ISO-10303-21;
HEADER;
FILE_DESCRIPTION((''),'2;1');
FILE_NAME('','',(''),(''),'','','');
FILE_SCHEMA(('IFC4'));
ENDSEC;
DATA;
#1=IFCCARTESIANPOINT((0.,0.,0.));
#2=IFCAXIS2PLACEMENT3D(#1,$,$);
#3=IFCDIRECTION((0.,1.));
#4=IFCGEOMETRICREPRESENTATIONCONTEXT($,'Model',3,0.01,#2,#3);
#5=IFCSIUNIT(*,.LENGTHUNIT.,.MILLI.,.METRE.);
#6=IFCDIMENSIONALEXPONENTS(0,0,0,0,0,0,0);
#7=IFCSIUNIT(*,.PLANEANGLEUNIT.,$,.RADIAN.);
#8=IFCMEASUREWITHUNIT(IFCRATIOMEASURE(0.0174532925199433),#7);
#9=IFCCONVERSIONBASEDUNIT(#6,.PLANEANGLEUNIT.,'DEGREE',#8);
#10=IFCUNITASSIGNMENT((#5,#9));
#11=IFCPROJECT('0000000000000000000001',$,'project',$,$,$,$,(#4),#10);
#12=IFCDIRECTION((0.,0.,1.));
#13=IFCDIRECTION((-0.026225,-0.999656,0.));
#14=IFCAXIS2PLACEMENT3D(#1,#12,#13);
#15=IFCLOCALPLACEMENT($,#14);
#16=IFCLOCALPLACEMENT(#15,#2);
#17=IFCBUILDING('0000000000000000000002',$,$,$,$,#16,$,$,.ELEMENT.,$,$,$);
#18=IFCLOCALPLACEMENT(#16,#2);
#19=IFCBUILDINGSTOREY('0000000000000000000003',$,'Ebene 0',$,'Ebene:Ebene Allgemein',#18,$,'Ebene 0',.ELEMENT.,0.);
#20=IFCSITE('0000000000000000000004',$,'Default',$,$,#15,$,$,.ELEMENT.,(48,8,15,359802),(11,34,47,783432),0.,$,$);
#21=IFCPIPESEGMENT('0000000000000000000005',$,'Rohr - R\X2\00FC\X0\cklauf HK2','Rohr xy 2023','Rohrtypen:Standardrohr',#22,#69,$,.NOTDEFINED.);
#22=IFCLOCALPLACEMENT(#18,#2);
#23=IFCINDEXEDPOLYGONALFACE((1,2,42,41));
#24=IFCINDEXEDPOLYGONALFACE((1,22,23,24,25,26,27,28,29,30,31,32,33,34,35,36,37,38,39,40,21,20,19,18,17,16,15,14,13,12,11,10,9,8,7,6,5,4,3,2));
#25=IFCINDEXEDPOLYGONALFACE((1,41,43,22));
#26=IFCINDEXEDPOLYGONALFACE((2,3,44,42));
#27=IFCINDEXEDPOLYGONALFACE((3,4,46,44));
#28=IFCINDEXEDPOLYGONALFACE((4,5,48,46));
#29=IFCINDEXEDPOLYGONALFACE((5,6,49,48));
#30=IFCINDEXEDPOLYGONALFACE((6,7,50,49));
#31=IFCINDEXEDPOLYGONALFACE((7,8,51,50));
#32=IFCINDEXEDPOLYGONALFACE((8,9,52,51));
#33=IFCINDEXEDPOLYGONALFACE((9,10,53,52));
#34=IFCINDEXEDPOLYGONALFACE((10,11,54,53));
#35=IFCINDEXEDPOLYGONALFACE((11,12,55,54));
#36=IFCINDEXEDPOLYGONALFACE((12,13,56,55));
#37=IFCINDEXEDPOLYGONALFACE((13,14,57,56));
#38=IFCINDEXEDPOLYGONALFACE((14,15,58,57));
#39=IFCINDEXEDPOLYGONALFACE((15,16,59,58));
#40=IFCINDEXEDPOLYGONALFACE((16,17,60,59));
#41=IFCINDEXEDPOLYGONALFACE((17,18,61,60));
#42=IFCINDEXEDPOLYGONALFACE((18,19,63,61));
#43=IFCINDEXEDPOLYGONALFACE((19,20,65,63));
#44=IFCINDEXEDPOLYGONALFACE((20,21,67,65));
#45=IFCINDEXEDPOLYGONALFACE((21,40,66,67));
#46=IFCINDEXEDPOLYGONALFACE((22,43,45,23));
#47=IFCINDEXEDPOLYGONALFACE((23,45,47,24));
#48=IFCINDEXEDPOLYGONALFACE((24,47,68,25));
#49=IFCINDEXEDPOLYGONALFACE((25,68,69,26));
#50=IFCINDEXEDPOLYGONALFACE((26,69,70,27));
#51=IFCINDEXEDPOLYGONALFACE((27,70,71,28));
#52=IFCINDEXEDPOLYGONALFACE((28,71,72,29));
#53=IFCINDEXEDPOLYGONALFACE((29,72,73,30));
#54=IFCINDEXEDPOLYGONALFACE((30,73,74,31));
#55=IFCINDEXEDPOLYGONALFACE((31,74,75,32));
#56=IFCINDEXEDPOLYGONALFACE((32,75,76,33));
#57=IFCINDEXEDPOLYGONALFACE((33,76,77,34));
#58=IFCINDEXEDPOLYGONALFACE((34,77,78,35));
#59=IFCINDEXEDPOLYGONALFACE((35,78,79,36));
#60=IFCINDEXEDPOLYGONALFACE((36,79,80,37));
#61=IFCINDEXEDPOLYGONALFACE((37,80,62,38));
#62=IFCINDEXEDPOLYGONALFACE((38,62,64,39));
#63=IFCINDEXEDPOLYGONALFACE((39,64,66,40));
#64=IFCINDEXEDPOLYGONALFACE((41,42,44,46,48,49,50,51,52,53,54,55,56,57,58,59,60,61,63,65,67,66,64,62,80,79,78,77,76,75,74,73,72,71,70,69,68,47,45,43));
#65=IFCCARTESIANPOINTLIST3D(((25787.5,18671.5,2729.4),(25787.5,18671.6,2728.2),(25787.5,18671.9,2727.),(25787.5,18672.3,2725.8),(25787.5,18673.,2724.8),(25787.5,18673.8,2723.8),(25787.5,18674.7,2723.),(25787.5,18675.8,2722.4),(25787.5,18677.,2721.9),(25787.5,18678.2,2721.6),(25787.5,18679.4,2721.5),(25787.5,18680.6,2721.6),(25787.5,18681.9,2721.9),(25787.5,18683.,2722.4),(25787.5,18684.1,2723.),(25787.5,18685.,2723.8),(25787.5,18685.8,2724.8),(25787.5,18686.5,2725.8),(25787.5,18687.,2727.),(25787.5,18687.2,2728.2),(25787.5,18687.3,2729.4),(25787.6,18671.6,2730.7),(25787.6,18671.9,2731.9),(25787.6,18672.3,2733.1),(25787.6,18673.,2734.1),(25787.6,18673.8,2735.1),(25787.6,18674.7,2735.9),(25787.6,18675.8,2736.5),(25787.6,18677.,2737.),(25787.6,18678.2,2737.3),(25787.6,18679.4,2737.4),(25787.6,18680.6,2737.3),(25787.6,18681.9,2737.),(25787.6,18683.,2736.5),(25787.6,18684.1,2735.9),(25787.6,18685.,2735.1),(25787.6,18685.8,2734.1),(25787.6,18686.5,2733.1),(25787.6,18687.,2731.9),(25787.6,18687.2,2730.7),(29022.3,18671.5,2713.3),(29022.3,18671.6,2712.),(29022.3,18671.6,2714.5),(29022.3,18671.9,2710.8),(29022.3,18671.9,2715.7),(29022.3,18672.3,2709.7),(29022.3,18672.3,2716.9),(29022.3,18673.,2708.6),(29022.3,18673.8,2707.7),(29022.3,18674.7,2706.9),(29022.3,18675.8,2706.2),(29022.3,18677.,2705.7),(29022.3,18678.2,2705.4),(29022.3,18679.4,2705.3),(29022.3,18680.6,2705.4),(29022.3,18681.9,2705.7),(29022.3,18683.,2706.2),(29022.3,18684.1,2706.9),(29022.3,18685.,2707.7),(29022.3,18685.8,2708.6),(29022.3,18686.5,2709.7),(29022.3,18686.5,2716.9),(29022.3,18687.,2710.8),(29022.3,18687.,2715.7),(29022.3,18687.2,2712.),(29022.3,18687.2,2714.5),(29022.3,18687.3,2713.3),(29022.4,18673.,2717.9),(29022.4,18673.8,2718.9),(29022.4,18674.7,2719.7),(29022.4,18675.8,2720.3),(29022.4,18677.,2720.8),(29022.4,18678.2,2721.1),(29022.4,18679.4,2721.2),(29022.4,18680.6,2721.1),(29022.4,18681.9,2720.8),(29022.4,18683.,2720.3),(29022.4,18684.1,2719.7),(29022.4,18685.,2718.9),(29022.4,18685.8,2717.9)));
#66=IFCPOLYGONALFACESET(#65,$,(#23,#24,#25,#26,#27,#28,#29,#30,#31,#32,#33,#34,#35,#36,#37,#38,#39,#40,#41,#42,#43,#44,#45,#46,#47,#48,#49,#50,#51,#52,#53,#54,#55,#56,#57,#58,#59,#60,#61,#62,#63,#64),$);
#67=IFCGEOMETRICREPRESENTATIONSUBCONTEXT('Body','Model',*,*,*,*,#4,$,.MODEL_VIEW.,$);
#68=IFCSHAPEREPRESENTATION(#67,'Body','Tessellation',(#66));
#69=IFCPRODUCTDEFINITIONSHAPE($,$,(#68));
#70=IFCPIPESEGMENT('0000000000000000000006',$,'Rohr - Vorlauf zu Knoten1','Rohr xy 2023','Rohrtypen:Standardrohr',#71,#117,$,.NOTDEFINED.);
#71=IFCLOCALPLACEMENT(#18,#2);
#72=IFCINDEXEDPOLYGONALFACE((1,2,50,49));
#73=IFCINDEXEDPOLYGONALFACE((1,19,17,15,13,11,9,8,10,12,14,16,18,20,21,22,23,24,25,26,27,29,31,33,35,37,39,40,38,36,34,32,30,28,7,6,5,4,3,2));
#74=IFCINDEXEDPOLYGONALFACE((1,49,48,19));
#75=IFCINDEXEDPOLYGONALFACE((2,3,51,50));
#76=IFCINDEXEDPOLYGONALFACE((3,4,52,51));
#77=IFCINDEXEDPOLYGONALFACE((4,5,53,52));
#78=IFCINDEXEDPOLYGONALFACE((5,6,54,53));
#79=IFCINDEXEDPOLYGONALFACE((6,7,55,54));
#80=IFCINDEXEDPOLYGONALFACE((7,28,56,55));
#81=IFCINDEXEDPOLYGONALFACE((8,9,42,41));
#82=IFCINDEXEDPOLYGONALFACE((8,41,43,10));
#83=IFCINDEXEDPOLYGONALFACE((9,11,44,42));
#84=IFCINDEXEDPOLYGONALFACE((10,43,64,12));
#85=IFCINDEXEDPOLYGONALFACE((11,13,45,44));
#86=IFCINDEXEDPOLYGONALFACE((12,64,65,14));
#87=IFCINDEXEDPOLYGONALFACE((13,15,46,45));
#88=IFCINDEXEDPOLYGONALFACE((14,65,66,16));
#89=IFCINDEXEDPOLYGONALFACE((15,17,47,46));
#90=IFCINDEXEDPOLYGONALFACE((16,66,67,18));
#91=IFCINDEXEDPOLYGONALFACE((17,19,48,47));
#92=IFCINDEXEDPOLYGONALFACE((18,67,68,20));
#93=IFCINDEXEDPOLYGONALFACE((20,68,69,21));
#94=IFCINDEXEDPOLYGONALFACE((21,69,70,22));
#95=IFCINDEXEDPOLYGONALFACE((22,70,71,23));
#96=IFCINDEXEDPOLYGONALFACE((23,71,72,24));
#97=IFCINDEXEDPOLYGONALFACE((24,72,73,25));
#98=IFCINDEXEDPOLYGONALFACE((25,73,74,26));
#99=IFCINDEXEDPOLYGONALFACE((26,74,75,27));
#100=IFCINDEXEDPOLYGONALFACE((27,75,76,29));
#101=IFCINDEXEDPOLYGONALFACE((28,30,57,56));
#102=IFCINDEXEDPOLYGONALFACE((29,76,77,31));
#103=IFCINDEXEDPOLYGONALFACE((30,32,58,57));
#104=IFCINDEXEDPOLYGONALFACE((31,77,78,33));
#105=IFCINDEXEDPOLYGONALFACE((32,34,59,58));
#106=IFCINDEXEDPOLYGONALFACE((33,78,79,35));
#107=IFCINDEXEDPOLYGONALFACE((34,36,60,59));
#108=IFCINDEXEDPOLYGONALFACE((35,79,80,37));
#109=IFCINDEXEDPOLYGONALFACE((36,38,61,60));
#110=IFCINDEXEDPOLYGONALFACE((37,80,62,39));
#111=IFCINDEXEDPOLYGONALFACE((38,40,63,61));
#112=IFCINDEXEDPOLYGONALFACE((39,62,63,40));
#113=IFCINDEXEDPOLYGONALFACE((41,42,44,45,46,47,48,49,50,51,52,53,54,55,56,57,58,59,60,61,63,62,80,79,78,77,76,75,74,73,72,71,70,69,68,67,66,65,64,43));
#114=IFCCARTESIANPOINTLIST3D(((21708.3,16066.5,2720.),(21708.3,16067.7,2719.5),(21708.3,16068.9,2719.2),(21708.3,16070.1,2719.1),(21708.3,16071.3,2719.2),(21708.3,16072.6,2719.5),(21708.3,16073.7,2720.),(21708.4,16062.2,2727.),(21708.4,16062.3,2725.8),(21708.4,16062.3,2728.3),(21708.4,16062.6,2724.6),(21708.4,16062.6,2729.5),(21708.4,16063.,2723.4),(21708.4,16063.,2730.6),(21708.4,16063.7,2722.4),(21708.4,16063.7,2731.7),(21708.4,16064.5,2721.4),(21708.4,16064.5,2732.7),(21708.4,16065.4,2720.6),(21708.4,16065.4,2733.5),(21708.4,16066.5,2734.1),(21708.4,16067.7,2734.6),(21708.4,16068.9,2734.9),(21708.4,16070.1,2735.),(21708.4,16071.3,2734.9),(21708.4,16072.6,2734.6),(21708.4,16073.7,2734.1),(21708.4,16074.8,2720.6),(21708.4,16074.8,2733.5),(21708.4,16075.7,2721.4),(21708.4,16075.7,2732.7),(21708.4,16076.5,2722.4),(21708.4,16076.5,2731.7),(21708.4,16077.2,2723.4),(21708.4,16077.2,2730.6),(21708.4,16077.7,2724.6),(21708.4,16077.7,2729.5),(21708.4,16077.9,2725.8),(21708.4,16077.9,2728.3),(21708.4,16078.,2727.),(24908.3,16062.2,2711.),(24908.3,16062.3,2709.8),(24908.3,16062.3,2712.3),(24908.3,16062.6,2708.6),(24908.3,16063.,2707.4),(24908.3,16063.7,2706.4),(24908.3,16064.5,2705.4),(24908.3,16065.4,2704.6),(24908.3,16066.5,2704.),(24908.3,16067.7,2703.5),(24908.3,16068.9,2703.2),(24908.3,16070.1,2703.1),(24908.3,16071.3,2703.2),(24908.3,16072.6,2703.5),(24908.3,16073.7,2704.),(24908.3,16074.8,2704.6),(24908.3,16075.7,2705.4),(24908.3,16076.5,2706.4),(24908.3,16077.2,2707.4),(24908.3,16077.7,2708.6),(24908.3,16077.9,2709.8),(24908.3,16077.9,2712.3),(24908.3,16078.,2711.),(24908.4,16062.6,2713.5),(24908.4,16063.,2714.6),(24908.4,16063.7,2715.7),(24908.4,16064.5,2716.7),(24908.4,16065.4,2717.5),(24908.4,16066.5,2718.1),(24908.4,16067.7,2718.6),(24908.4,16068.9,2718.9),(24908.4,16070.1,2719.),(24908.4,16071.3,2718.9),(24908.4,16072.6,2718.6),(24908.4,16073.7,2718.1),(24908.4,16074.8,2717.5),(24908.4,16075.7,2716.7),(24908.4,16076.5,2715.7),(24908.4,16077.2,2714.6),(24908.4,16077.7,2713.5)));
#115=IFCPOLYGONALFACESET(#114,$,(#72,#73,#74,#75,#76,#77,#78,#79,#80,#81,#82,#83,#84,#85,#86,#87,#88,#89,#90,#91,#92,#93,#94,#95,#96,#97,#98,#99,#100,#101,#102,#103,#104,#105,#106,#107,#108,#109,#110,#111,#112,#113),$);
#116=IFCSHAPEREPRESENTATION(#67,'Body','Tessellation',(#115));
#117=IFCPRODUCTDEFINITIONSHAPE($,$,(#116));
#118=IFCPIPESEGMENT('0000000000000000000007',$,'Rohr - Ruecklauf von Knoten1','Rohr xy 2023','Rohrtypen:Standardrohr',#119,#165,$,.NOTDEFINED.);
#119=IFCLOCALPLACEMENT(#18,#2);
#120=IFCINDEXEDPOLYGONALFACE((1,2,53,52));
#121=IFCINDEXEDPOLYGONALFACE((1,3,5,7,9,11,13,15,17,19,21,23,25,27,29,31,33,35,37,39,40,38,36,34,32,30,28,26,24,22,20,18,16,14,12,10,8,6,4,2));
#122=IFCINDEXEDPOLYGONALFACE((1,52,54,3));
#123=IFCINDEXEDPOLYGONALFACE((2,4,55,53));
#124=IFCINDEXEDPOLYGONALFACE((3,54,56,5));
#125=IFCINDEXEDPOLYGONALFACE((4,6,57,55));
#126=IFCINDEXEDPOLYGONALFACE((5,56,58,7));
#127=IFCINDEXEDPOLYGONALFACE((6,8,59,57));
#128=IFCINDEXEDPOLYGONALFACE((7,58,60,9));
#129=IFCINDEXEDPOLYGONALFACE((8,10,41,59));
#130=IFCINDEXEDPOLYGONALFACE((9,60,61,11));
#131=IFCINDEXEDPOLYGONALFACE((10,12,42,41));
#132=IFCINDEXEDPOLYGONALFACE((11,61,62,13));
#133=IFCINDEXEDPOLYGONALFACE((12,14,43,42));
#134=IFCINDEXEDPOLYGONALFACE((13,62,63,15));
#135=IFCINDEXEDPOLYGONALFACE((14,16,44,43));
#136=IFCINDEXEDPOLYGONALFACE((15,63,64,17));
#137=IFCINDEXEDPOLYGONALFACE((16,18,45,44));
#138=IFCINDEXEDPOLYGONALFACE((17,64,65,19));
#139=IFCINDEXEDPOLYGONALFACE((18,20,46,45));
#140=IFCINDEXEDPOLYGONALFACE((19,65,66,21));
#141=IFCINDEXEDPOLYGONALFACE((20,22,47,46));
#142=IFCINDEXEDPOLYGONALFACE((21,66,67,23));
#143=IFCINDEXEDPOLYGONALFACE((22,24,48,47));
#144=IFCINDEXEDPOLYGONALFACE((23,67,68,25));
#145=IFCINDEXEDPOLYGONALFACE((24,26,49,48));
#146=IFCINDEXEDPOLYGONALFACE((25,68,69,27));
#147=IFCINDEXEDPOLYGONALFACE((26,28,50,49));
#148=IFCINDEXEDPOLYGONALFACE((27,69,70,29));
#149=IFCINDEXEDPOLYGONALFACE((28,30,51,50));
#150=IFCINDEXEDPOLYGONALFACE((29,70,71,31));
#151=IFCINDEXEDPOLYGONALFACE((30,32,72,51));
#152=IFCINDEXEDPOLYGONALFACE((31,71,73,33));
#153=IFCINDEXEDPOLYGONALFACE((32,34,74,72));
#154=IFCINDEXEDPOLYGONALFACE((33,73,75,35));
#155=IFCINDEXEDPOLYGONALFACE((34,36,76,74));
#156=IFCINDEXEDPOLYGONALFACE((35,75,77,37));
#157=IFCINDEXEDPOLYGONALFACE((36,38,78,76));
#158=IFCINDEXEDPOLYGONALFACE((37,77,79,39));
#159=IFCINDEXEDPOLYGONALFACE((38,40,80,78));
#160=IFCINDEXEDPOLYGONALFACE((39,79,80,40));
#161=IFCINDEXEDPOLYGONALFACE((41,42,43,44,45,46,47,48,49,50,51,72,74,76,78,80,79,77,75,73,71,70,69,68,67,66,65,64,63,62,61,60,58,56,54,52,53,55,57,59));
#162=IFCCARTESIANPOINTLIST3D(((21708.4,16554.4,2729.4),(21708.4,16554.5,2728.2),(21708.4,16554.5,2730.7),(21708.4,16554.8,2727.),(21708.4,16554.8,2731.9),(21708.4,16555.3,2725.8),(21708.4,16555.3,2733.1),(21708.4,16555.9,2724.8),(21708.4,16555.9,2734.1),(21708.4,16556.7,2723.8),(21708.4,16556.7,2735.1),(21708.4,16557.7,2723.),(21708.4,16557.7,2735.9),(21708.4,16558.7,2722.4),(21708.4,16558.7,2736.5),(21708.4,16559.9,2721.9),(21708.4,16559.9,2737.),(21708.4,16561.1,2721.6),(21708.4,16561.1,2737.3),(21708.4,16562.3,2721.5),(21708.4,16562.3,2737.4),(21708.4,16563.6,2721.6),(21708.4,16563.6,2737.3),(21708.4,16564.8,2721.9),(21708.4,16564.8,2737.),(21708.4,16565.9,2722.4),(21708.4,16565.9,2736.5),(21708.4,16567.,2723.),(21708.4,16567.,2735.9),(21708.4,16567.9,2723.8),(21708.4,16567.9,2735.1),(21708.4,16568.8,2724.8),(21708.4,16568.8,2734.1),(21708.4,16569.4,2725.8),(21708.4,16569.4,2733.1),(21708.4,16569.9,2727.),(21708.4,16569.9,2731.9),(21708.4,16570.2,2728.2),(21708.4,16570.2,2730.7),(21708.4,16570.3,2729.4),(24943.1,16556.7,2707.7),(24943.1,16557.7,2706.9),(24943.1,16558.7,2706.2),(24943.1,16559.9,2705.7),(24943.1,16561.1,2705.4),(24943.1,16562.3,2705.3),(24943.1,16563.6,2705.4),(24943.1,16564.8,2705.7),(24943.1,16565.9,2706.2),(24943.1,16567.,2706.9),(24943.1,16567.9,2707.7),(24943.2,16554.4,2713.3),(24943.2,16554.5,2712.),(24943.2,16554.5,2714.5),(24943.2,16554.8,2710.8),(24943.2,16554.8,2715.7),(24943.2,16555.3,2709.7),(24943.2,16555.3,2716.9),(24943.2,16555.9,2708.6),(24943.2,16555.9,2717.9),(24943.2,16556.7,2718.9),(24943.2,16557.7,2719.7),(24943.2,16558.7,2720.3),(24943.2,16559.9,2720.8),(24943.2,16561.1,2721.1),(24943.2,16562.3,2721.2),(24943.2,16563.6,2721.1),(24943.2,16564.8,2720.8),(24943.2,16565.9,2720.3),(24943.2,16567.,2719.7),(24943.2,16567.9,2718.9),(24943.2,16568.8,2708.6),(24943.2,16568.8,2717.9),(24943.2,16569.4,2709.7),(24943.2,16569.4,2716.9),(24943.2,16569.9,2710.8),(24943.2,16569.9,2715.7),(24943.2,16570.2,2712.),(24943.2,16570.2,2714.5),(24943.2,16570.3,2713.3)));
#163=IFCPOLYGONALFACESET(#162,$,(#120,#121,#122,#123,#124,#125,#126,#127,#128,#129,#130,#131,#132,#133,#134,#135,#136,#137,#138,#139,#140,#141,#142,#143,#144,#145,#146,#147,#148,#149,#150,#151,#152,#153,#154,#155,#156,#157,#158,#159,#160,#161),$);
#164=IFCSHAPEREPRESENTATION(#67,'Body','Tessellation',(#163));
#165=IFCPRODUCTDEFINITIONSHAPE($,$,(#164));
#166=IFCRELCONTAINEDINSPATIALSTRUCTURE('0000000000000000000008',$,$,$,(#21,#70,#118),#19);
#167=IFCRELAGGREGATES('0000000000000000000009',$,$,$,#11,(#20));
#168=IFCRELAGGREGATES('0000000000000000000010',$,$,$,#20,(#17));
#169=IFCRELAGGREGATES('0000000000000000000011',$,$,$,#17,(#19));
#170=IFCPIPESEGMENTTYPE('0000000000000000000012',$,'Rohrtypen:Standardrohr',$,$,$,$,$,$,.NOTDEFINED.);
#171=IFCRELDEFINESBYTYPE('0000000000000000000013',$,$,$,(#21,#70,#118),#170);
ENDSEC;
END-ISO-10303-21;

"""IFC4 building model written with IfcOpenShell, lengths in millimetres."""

from ifc_helpers import new_model, entity, si_unit, converted_unit, direction, frame, origin, place, context, subcontext, project, spatial, indexed_curve, outline, extrude, type_object, element, save


model = new_model("IFC4")

# Units and contexts
model_context = context("Model", 3, precision=0.01, world=origin(), true_north=direction((0.0, 1.0)))
body_context = subcontext(model_context, "Body", "Model", "MODEL_VIEW")
ifc_project = project(units=[si_unit("LENGTHUNIT", "METRE", prefix="MILLI"), converted_unit("PLANEANGLEUNIT", "DEGREE", entity("IfcRatioMeasure", 0.0174532925199433), si_unit("PLANEANGLEUNIT", "RADIAN"), dimensions=[0, 0, 0, 0, 0, 0, 0])], contexts=[model_context])

# Site, building, storey
site_placement = place(None, frame((0.0, 0.0, 0.0), z_axis=(0.0, 0.0, 1.0), x_axis=(-0.026225, -0.999656, 0.0)))
site = spatial("IfcSite", under=ifc_project, at=site_placement, Name="Default", CompositionType="ELEMENT", RefLatitude=(48, 8, 15, 359802), RefLongitude=(11, 34, 47, 783432), RefElevation=0.0)
building_placement = place(site_placement, origin())
building = spatial("IfcBuilding", under=site, at=building_placement, CompositionType="ELEMENT")
storey_placement = place(building_placement, origin())
storey = spatial("IfcBuildingStorey", under=building, at=storey_placement, Name="Ebene 0", ObjectType="Ebene:Ebene Allgemein", LongName="Ebene 0", CompositionType="ELEMENT", Elevation=0.0)

# Pipe segments
pipe_segment_type = type_object("IfcPipeSegmentType", Name="Rohrtypen:Standardrohr", PredefinedType="NOTDEFINED")
pipe_segment_1_placement = place(storey_placement, origin())
element("IfcPipeSegment", 1, at=pipe_segment_1_placement, inside=storey, type_object=pipe_segment_type, Name="Rohr - Rücklauf HK2", Description="Rohr xy 2023", ObjectType="Rohrtypen:Standardrohr", PredefinedType="NOTDEFINED", context=body_context, shape_type="SweptSolid", body=[
    extrude(outline(indexed_curve([(7.9, 0.0), (7.8, 1.2), (7.6, 2.5), (7.1, 3.6), (6.4, 4.7), (5.6, 5.6), (4.7, 6.4), (3.6, 7.1), (2.5, 7.6), (1.2, 7.8), (0.0, 7.9), (-1.2, 7.8), (-2.5, 7.6), (-3.6, 7.1), (-4.7, 6.4), (-5.6, 5.6), (-6.4, 4.7), (-7.1, 3.6), (-7.6, 2.5), (-7.8, 1.2), (-7.9, 0.0), (-7.8, -1.2), (-7.6, -2.5), (-7.1, -3.6), (-6.4, -4.7), (-5.6, -5.6), (-4.7, -6.4), (-3.6, -7.1), (-2.5, -7.6), (-1.2, -7.8), (0.0, -7.9), (1.2, -7.8), (2.5, -7.6), (3.6, -7.1), (4.7, -6.4), (5.6, -5.6), (6.4, -4.7), (7.1, -3.6), (7.6, -2.5), (7.8, -1.2), (7.9, 0.0)], self_intersect=False)), frame((29022.3, 18679.4, 2713.3), z_axis=(-0.999988, 0.0, 0.005), x_axis=(0.0, 1.0, 0.0)), (0.0, 0.0, 1.0), 3234.8),
])
pipe_segment_2_placement = place(storey_placement, origin())
element("IfcPipeSegment", 2, at=pipe_segment_2_placement, inside=storey, type_object=pipe_segment_type, Name="Rohr - Vorlauf zu Knoten1", Description="Rohr xy 2023", ObjectType="Rohrtypen:Standardrohr", PredefinedType="NOTDEFINED", context=body_context, shape_type="SweptSolid", body=[
    extrude(outline(indexed_curve([(7.9, 0.0), (7.8, 1.2), (7.6, 2.5), (7.1, 3.6), (6.4, 4.7), (5.6, 5.6), (4.7, 6.4), (3.6, 7.1), (2.5, 7.6), (1.2, 7.8), (0.0, 7.9), (-1.2, 7.8), (-2.5, 7.6), (-3.6, 7.1), (-4.7, 6.4), (-5.6, 5.6), (-6.4, 4.7), (-7.1, 3.6), (-7.6, 2.5), (-7.8, 1.2), (-7.9, 0.0), (-7.8, -1.2), (-7.6, -2.5), (-7.1, -3.6), (-6.4, -4.7), (-5.6, -5.6), (-4.7, -6.4), (-3.6, -7.1), (-2.5, -7.6), (-1.2, -7.8), (0.0, -7.9), (1.2, -7.8), (2.5, -7.6), (3.6, -7.1), (4.7, -6.4), (5.6, -5.6), (6.4, -4.7), (7.1, -3.6), (7.6, -2.5), (7.8, -1.2), (7.9, 0.0)], self_intersect=False)), frame((24908.3, 16070.1, 2711.0), z_axis=(-0.999988, 0.0, 0.005), x_axis=(0.0, 1.0, 0.0)), (0.0, 0.0, 1.0), 3200.0),
])
pipe_segment_3_placement = place(storey_placement, origin())
element("IfcPipeSegment", 3, at=pipe_segment_3_placement, inside=storey, type_object=pipe_segment_type, Name="Rohr - Ruecklauf von Knoten1", Description="Rohr xy 2023", ObjectType="Rohrtypen:Standardrohr", PredefinedType="NOTDEFINED", context=body_context, shape_type="SweptSolid", body=[
    extrude(outline(indexed_curve([(7.9, 0.0), (7.8, 1.2), (7.6, 2.5), (7.1, 3.6), (6.4, 4.7), (5.6, 5.6), (4.7, 6.4), (3.6, 7.1), (2.5, 7.6), (1.2, 7.8), (0.0, 7.9), (-1.2, 7.8), (-2.5, 7.6), (-3.6, 7.1), (-4.7, 6.4), (-5.6, 5.6), (-6.4, 4.7), (-7.1, 3.6), (-7.6, 2.5), (-7.8, 1.2), (-7.9, 0.0), (-7.8, -1.2), (-7.6, -2.5), (-7.1, -3.6), (-6.4, -4.7), (-5.6, -5.6), (-4.7, -6.4), (-3.6, -7.1), (-2.5, -7.6), (-1.2, -7.8), (0.0, -7.9), (1.2, -7.8), (2.5, -7.6), (3.6, -7.1), (4.7, -6.4), (5.6, -5.6), (6.4, -4.7), (7.1, -3.6), (7.6, -2.5), (7.8, -1.2), (7.9, 0.0)], self_intersect=False)), frame((24943.2, 16562.3, 2713.3), z_axis=(-0.999988, 0.0, 0.005), x_axis=(0.0, 1.0, 0.0)), (0.0, 0.0, 1.0), 3234.8),
])

save(model, "model.ifc")
